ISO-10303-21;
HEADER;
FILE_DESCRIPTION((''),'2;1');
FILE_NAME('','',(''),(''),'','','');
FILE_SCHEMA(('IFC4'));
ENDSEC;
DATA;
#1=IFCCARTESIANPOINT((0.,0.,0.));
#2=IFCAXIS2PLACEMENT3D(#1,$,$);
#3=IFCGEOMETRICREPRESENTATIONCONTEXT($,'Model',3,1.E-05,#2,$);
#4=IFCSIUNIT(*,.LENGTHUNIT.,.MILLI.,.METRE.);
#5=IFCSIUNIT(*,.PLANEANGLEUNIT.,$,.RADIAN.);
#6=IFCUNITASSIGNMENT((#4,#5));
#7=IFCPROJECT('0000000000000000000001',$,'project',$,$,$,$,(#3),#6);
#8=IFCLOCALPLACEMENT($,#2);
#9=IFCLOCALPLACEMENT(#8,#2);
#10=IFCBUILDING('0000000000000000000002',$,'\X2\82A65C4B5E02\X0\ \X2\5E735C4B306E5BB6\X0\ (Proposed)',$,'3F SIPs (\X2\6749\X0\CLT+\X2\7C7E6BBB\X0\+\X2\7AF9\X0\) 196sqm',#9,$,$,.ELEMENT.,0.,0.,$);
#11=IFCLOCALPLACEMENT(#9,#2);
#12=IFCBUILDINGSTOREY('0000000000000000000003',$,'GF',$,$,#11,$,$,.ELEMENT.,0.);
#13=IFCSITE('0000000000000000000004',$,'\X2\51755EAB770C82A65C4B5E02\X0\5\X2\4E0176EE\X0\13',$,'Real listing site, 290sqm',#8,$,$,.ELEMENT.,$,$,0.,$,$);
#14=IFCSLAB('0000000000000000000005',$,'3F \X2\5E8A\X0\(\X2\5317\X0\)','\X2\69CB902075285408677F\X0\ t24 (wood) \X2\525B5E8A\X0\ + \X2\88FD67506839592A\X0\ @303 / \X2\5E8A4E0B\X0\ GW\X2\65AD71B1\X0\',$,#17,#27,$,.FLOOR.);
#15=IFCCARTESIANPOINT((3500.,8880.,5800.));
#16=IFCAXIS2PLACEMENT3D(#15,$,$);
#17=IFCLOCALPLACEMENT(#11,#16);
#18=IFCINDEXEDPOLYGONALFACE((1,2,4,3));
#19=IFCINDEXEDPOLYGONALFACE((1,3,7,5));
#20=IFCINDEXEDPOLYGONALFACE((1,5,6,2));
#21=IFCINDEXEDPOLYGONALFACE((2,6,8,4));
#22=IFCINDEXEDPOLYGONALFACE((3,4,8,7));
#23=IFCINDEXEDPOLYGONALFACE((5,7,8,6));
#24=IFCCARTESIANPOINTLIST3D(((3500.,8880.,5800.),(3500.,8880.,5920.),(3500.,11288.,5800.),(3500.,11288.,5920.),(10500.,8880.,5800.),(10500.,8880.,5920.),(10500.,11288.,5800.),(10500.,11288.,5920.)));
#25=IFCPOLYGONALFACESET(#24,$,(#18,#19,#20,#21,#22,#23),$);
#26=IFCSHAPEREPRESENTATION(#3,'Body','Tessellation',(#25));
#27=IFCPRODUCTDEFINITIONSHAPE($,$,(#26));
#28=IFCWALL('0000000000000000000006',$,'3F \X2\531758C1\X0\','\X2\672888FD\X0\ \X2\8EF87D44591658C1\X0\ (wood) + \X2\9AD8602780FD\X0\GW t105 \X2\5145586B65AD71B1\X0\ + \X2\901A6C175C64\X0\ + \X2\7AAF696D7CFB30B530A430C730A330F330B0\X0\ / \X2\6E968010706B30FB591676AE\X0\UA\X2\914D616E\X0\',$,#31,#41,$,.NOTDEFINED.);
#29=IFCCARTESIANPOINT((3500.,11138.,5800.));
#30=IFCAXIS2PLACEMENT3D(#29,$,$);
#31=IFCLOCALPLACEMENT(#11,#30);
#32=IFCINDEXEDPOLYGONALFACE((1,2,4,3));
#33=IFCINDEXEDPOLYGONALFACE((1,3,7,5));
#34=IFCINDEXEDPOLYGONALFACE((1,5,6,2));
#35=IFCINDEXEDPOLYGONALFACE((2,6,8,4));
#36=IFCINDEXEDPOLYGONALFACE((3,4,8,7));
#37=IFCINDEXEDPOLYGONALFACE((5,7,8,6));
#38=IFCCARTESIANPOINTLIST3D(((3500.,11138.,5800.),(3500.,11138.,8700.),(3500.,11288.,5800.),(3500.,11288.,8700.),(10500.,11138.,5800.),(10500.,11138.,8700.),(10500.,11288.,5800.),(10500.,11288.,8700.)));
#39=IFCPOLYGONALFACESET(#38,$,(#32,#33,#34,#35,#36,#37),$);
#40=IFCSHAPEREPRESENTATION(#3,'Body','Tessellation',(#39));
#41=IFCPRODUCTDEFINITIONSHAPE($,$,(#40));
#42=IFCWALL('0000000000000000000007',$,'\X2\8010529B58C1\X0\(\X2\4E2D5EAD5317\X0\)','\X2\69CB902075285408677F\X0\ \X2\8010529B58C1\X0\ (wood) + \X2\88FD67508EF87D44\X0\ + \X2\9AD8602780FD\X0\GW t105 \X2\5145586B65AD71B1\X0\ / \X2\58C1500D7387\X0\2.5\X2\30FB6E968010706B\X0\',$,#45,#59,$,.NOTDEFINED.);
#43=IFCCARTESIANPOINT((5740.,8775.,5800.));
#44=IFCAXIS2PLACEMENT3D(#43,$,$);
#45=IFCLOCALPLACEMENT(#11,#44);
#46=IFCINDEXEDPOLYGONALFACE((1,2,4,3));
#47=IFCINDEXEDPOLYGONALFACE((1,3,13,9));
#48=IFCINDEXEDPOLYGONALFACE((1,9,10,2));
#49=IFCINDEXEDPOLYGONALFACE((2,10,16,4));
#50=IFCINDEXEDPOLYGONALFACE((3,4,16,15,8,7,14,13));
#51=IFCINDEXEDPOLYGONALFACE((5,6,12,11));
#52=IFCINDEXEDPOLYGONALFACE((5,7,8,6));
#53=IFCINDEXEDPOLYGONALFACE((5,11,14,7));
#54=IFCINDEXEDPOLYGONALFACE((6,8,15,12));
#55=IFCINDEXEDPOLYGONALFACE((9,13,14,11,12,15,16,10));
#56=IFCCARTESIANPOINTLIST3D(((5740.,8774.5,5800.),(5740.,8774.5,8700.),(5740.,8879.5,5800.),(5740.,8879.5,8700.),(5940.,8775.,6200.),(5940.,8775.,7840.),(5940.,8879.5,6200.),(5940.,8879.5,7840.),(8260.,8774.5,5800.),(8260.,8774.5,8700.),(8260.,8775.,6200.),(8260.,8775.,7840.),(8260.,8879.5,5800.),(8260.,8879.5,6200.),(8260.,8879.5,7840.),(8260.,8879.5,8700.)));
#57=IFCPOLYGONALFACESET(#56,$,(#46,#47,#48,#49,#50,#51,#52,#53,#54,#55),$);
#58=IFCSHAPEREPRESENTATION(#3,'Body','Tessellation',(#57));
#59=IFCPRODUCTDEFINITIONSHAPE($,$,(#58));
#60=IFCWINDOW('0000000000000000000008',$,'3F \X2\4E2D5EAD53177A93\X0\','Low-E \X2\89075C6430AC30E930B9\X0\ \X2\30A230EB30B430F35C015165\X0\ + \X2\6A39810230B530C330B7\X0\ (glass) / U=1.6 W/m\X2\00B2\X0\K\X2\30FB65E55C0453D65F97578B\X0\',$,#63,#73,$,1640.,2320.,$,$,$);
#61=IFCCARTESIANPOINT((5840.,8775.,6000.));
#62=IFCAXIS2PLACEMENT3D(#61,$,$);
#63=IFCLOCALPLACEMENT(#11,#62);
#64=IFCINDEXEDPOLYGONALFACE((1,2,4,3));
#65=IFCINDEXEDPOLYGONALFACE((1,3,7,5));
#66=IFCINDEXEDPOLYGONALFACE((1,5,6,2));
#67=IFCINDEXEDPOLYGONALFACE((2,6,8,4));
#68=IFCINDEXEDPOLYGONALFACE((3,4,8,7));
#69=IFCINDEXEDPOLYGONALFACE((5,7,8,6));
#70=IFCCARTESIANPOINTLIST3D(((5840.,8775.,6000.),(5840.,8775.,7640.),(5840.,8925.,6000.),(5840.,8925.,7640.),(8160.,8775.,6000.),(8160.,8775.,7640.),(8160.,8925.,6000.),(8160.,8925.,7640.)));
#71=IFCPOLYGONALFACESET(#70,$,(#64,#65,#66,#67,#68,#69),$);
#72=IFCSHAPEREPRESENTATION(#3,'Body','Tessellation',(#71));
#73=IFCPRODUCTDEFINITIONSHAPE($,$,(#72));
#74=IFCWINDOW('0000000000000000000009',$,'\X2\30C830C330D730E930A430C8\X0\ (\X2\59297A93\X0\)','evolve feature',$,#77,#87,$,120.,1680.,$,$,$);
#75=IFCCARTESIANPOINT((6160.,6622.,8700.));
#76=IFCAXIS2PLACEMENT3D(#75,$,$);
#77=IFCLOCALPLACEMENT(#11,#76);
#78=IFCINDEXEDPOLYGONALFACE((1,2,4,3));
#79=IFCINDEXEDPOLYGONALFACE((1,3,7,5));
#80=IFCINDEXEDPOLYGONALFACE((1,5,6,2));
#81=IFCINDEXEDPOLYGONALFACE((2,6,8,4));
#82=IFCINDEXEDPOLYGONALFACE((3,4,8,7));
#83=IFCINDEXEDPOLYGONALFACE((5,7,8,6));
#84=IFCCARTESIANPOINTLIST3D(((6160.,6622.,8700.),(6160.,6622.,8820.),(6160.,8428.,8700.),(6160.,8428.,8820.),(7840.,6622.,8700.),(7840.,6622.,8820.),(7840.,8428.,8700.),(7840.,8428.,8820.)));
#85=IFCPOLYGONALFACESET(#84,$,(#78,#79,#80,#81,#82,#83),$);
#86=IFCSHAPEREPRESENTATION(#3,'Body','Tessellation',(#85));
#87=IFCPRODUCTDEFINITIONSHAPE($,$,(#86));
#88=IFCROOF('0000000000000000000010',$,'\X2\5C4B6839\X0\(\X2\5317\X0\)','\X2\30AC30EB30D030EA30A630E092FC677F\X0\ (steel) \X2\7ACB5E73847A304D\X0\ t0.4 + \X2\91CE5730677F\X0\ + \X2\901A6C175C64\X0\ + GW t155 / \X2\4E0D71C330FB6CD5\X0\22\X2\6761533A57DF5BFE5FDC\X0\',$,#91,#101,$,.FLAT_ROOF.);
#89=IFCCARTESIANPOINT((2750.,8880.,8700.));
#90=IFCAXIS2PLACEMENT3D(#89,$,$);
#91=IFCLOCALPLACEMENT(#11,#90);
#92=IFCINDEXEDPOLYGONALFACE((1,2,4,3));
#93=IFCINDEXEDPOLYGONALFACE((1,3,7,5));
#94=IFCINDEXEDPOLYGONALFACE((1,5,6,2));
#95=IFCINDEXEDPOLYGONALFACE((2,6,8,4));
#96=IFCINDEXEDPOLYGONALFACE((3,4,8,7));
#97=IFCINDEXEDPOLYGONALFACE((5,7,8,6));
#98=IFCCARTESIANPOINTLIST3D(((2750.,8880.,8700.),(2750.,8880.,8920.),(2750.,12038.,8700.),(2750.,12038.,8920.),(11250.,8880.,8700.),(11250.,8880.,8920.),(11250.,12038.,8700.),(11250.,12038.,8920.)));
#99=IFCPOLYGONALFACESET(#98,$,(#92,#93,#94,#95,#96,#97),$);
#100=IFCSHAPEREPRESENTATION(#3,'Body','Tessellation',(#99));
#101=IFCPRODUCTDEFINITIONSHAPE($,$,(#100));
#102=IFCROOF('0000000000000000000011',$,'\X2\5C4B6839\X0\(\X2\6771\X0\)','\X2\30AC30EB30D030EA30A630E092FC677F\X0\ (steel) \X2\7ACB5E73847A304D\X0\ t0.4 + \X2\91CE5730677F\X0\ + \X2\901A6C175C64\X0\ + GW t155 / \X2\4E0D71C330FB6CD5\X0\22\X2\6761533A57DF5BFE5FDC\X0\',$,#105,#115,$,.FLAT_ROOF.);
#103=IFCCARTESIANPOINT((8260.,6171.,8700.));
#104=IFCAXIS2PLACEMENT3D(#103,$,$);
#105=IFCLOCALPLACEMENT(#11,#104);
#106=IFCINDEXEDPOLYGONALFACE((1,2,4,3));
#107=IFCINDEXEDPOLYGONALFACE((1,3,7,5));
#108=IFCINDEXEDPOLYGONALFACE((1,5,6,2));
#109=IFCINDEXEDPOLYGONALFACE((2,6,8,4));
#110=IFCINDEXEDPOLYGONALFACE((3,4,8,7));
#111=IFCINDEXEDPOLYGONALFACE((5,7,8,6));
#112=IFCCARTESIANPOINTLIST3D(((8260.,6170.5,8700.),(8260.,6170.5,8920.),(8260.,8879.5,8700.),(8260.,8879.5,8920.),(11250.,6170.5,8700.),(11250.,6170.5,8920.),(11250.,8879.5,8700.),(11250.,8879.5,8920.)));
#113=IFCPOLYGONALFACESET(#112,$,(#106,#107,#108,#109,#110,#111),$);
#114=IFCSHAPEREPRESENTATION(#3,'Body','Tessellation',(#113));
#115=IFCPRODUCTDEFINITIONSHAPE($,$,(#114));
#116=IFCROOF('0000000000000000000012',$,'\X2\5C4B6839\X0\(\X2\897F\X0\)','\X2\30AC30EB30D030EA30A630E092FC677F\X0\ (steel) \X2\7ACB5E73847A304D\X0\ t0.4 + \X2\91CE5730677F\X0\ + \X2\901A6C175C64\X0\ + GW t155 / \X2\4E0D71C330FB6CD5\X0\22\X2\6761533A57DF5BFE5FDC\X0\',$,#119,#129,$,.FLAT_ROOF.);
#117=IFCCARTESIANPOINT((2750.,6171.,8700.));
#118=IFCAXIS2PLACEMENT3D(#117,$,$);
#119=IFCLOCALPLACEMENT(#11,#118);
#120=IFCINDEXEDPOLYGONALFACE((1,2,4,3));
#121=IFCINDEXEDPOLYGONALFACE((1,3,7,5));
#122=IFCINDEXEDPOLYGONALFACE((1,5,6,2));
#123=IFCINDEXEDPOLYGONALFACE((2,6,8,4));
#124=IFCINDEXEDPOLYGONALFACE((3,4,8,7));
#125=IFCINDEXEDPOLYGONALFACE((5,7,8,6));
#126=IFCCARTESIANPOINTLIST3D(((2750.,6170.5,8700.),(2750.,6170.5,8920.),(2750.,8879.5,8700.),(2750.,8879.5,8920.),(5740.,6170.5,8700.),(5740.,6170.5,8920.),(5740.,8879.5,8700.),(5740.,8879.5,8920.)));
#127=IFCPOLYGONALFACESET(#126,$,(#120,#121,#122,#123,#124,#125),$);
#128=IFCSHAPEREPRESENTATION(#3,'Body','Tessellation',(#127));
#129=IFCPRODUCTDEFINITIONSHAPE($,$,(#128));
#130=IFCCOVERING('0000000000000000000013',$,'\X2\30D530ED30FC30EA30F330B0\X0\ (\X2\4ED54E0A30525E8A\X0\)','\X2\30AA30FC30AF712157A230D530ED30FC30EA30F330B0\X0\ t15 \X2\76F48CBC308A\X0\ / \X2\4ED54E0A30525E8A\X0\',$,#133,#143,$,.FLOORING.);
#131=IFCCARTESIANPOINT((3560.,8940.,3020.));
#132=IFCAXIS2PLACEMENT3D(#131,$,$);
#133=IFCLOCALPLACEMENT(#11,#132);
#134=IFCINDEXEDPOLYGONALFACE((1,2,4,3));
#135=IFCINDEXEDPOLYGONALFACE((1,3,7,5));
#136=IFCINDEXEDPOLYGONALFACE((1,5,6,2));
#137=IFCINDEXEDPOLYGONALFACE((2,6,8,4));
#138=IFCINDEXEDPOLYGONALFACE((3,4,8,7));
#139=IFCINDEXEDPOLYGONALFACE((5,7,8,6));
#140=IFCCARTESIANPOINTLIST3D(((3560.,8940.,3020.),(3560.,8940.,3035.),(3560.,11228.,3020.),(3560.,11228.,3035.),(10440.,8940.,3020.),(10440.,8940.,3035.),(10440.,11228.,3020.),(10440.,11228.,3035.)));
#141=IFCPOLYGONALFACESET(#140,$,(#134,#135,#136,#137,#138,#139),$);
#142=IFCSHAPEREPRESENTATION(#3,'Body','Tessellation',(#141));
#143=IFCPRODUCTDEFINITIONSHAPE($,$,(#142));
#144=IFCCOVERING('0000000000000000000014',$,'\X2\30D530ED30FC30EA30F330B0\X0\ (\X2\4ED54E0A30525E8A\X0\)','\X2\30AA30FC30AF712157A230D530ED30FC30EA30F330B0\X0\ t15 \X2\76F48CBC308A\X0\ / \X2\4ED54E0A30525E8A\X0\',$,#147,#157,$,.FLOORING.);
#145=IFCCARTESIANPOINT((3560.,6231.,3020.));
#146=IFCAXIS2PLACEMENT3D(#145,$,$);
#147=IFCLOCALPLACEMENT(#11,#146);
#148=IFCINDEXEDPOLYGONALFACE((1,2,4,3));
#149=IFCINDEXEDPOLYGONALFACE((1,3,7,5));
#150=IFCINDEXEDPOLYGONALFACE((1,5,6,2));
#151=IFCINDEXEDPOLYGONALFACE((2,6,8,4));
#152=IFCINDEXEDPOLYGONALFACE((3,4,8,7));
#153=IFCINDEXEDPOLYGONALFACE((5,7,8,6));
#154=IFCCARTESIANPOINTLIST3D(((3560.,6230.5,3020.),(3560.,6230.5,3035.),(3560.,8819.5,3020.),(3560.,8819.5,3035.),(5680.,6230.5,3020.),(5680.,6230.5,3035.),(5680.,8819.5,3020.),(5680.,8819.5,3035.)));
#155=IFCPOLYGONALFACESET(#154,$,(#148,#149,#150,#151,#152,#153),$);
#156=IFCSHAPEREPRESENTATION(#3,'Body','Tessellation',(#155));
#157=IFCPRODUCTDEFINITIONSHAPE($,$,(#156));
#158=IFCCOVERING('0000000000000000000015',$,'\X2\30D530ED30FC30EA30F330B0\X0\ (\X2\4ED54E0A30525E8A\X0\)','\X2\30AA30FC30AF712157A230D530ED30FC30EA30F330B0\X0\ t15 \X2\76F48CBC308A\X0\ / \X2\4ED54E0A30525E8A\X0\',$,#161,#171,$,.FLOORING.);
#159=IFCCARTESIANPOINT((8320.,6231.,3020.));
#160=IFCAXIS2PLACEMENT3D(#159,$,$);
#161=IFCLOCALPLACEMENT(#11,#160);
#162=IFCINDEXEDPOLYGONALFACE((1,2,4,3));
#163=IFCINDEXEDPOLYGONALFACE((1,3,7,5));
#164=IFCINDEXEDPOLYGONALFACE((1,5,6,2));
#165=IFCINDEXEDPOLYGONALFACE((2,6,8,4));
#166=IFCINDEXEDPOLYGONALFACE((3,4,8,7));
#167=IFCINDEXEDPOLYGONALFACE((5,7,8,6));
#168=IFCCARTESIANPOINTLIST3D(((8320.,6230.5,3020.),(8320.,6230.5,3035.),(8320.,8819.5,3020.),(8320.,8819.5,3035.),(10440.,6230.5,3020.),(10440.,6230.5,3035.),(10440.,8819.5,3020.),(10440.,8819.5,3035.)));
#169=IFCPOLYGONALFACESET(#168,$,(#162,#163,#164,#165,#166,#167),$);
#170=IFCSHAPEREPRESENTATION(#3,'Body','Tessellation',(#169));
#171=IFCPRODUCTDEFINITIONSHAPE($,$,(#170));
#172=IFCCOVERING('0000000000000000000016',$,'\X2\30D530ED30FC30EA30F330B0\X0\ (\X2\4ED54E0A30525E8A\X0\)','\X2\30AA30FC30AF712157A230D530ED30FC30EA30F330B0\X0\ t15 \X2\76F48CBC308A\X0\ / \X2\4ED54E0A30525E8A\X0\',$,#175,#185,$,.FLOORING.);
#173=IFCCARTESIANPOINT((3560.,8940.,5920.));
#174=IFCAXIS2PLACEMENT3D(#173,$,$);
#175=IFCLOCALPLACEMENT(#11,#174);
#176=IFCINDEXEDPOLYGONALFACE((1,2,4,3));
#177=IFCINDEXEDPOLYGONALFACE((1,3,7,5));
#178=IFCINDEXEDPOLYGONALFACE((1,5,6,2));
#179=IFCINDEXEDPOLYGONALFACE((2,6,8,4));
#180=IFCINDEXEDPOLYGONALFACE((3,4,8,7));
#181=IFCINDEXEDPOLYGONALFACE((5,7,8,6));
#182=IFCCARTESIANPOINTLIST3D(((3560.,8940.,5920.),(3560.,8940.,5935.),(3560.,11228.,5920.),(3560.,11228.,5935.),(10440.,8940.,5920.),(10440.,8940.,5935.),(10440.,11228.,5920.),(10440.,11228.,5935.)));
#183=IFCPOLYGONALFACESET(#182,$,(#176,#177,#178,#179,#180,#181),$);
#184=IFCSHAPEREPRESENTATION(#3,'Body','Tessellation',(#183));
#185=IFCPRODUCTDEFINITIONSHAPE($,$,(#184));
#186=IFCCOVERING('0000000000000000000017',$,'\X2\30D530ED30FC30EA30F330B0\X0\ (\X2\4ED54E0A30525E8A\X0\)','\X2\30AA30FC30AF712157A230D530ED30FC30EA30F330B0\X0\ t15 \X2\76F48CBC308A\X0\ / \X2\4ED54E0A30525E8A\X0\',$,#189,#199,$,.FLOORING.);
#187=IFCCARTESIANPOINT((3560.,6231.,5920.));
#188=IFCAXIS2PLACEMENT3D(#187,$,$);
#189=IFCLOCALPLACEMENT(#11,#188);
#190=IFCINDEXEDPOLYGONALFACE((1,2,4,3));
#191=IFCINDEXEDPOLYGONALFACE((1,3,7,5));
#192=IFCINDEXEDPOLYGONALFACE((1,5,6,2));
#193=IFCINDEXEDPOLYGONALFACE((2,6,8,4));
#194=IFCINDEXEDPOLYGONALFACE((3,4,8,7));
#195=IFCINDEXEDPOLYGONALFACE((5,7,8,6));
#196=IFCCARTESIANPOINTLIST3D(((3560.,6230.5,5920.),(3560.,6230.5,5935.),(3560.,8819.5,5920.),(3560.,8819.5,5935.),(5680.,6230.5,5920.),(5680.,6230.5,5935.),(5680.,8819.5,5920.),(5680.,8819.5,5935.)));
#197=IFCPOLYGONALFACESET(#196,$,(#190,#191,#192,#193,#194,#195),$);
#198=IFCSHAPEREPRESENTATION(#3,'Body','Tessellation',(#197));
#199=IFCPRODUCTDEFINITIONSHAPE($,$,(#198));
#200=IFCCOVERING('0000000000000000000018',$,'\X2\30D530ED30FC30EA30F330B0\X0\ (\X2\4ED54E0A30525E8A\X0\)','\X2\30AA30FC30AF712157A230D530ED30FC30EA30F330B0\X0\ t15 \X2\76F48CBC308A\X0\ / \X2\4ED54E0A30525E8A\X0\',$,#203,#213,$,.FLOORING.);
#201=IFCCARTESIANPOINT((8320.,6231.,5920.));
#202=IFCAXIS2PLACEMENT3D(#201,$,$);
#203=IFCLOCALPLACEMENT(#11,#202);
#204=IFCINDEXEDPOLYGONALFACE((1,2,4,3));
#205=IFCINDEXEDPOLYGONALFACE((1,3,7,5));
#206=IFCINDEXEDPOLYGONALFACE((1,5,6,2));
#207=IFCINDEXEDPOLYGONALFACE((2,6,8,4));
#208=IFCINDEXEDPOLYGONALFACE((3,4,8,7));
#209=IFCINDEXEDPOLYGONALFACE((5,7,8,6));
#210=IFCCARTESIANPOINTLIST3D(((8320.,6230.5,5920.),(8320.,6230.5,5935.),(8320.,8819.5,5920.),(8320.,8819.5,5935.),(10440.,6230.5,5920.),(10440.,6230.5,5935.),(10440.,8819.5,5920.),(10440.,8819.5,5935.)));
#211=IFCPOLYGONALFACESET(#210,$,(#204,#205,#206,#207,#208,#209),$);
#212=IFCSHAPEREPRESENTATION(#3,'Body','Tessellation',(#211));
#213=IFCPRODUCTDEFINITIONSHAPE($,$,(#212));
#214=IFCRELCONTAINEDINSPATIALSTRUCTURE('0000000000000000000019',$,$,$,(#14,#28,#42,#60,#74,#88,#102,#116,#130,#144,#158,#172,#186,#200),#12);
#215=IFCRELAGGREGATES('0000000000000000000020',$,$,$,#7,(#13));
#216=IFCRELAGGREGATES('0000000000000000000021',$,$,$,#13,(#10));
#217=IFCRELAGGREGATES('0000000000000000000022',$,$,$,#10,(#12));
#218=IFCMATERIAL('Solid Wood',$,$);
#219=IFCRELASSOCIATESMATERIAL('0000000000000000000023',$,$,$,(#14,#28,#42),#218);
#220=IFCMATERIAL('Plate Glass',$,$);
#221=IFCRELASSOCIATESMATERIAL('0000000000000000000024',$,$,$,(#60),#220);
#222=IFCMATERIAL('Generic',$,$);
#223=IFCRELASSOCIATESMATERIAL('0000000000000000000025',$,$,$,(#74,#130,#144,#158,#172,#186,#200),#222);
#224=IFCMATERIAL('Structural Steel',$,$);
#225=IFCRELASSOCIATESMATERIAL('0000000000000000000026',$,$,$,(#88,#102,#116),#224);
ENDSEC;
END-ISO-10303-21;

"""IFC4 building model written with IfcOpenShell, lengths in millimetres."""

from ifc_helpers import new_model, si_unit, frame, frame_2d, origin, place, context, project, spatial, rectangle, extrude, material, element, fill, save


model = new_model("IFC4")

# Units and contexts
model_context = context("Model", 3, precision=1e-05, world=origin())
ifc_project = project(units=[si_unit("LENGTHUNIT", "METRE", prefix="MILLI"), si_unit("PLANEANGLEUNIT", "RADIAN")], contexts=[model_context])

# Site, building, storey
site_placement = place(None, origin())
site = spatial("IfcSite", under=ifc_project, at=site_placement, Name="兵庫県芦屋市5丁目13", ObjectType="Real listing site, 290sqm", CompositionType="ELEMENT", RefElevation=0.0)
building_placement = place(site_placement, origin())
building = spatial("IfcBuilding", under=site, at=building_placement, Name="芦屋市 平屋の家 (Proposed)", ObjectType="3F SIPs (杉CLT+籾殻+竹) 196sqm", CompositionType="ELEMENT", ElevationOfRefHeight=0.0, ElevationOfTerrain=0.0)
storey_placement = place(building_placement, origin())
storey = spatial("IfcBuildingStorey", under=building, at=storey_placement, Name="GF", CompositionType="ELEMENT", Elevation=0.0)

# Slab
ifc_material_1 = material(Name="Solid Wood")
slab_placement = place(storey_placement, frame((3500.0, 8880.0, 5800.0)))
element("IfcSlab", 1, at=slab_placement, inside=storey, material=ifc_material_1, Name="3F 床(北)", Description="構造用合板 t24 (wood) 剛床 + 製材根太 @303 / 床下 GW断熱", PredefinedType="FLOOR", context=model_context, shape_type="SweptSolid", body=[
    extrude(rectangle(XDim=7000.0, YDim=2408.0, at=frame_2d((3500.0, 1204.0))), frame((3500.0, 8880.0, 5800.0)), (0.0, 0.0, 1.0), 120.0),
])

# Wall
wall_1_placement = place(storey_placement, frame((3500.0, 11138.0, 5800.0)))
element("IfcWall", 2, at=wall_1_placement, inside=storey, material=ifc_material_1, Name="3F 北壁", Description="木製 軸組外壁 (wood) + 高性能GW t105 充填断熱 + 通気層 + 窯業系サイディング / 準耐火・外皮UA配慮", PredefinedType="NOTDEFINED", context=model_context, shape_type="SweptSolid", body=[
    extrude(rectangle(XDim=7000.0, YDim=150.0, at=frame_2d((3500.0, 75.0))), frame((3500.0, 11138.0, 5800.0)), (0.0, 0.0, 1.0), 2900.0),
])

# Wall, opening, window
wall_2_placement = place(storey_placement, frame((5740.0, 8775.0, 5800.0)))
wall_2 = element("IfcWall", 3, at=wall_2_placement, inside=storey, material=ifc_material_1, Name="耐力壁(中庭北)", Description="構造用合板 耐力壁 (wood) + 製材軸組 + 高性能GW t105 充填断熱 / 壁倍率2.5・準耐火", PredefinedType="NOTDEFINED", context=model_context, shape_type="SweptSolid", body=[
    extrude(rectangle(XDim=2520.0, YDim=105.0, at=frame_2d((1260.0, 52.0))), frame((5740.0, 8775.0, 5800.0)), (0.0, 0.0, 1.0), 2900.0),
])
opening_placement = place(storey_placement, frame((5840.0, 8775.0, 6000.0)))
opening = element("IfcOpeningElement", 4, at=opening_placement, cuts=wall_2, PredefinedType="NOTDEFINED", context=model_context, shape_type="SweptSolid", body=[
    extrude(rectangle(XDim=2320.0, YDim=150.0, at=frame_2d((1160.0, 75.0))), frame((5840.0, 8775.0, 6000.0)), (0.0, 0.0, 1.0), 1640.0),
])
ifc_material_2 = material(Name="Plate Glass")
window_1_placement = place(storey_placement, frame((5840.0, 8775.0, 6000.0)))
window_1 = element("IfcWindow", 5, at=window_1_placement, inside=storey, material=ifc_material_2, Name="3F 中庭北窓", Description="Low-E 複層ガラス アルゴン封入 + 樹脂サッシ (glass) / U=1.6 W/m²K・日射取得型", OverallHeight=1640.0, OverallWidth=2320.0, context=model_context, shape_type="SweptSolid", body=[
    extrude(rectangle(XDim=2320.0, YDim=150.0, at=frame_2d((1160.0, 75.0))), frame((5840.0, 8775.0, 6000.0)), (0.0, 0.0, 1.0), 1640.0),
])
fill(opening, window_1)

# Window
ifc_material_3 = material(Name="Generic")
window_2_placement = place(storey_placement, frame((6160.0, 6622.0, 8700.0)))
element("IfcWindow", 6, at=window_2_placement, inside=storey, material=ifc_material_3, Name="トップライト (天窓)", Description="evolve feature", OverallHeight=120.0, OverallWidth=1680.0, context=model_context, shape_type="SweptSolid", body=[
    extrude(rectangle(XDim=1680.0, YDim=1806.0, at=frame_2d((840.0, 903.0))), frame((6160.0, 6622.0, 8700.0)), (0.0, 0.0, 1.0), 120.0),
])

# Roofs
ifc_material_4 = material(Name="Structural Steel")
roof_1_placement = place(storey_placement, frame((2750.0, 8880.0, 8700.0)))
element("IfcRoof", 7, at=roof_1_placement, inside=storey, material=ifc_material_4, Name="屋根(北)", Description="ガルバリウム鋼板 (steel) 立平葺き t0.4 + 野地板 + 通気層 + GW t155 / 不燃・法22条区域対応", PredefinedType="FLAT_ROOF", context=model_context, shape_type="SweptSolid", body=[
    extrude(rectangle(XDim=8500.0, YDim=3158.0, at=frame_2d((4250.0, 1579.0))), frame((2750.0, 8880.0, 8700.0)), (0.0, 0.0, 1.0), 220.0),
])
roof_2_placement = place(storey_placement, frame((8260.0, 6171.0, 8700.0)))
element("IfcRoof", 8, at=roof_2_placement, inside=storey, material=ifc_material_4, Name="屋根(東)", Description="ガルバリウム鋼板 (steel) 立平葺き t0.4 + 野地板 + 通気層 + GW t155 / 不燃・法22条区域対応", PredefinedType="FLAT_ROOF", context=model_context, shape_type="SweptSolid", body=[
    extrude(rectangle(XDim=2990.0, YDim=2709.0, at=frame_2d((1495.0, 1354.0))), frame((8260.0, 6171.0, 8700.0)), (0.0, 0.0, 1.0), 220.0),
])
roof_3_placement = place(storey_placement, frame((2750.0, 6171.0, 8700.0)))
element("IfcRoof", 9, at=roof_3_placement, inside=storey, material=ifc_material_4, Name="屋根(西)", Description="ガルバリウム鋼板 (steel) 立平葺き t0.4 + 野地板 + 通気層 + GW t155 / 不燃・法22条区域対応", PredefinedType="FLAT_ROOF", context=model_context, shape_type="SweptSolid", body=[
    extrude(rectangle(XDim=2990.0, YDim=2709.0, at=frame_2d((1495.0, 1354.0))), frame((2750.0, 6171.0, 8700.0)), (0.0, 0.0, 1.0), 220.0),
])

# Coverings
covering_1_placement = place(storey_placement, frame((3560.0, 8940.0, 3020.0)))
element("IfcCovering", 10, at=covering_1_placement, inside=storey, material=ifc_material_3, Name="フローリング (仕上げ床)", Description="オーク無垢フローリング t15 直貼り / 仕上げ床", PredefinedType="FLOORING", context=model_context, shape_type="SweptSolid", body=[
    extrude(rectangle(XDim=6880.0, YDim=2288.0, at=frame_2d((3440.0, 1144.0))), frame((3560.0, 8940.0, 3020.0)), (0.0, 0.0, 1.0), 15.0),
])
covering_2_placement = place(storey_placement, frame((3560.0, 6231.0, 3020.0)))
element("IfcCovering", 11, at=covering_2_placement, inside=storey, material=ifc_material_3, Name="フローリング (仕上げ床)", Description="オーク無垢フローリング t15 直貼り / 仕上げ床", PredefinedType="FLOORING", context=model_context, shape_type="SweptSolid", body=[
    extrude(rectangle(XDim=2120.0, YDim=2589.0, at=frame_2d((1060.0, 1294.0))), frame((3560.0, 6231.0, 3020.0)), (0.0, 0.0, 1.0), 15.0),
])
covering_3_placement = place(storey_placement, frame((8320.0, 6231.0, 3020.0)))
element("IfcCovering", 12, at=covering_3_placement, inside=storey, material=ifc_material_3, Name="フローリング (仕上げ床)", Description="オーク無垢フローリング t15 直貼り / 仕上げ床", PredefinedType="FLOORING", context=model_context, shape_type="SweptSolid", body=[
    extrude(rectangle(XDim=2120.0, YDim=2589.0, at=frame_2d((1060.0, 1294.0))), frame((8320.0, 6231.0, 3020.0)), (0.0, 0.0, 1.0), 15.0),
])
covering_4_placement = place(storey_placement, frame((3560.0, 8940.0, 5920.0)))
element("IfcCovering", 13, at=covering_4_placement, inside=storey, material=ifc_material_3, Name="フローリング (仕上げ床)", Description="オーク無垢フローリング t15 直貼り / 仕上げ床", PredefinedType="FLOORING", context=model_context, shape_type="SweptSolid", body=[
    extrude(rectangle(XDim=6880.0, YDim=2288.0, at=frame_2d((3440.0, 1144.0))), frame((3560.0, 8940.0, 5920.0)), (0.0, 0.0, 1.0), 15.0),
])
covering_5_placement = place(storey_placement, frame((3560.0, 6231.0, 5920.0)))
element("IfcCovering", 14, at=covering_5_placement, inside=storey, material=ifc_material_3, Name="フローリング (仕上げ床)", Description="オーク無垢フローリング t15 直貼り / 仕上げ床", PredefinedType="FLOORING", context=model_context, shape_type="SweptSolid", body=[
    extrude(rectangle(XDim=2120.0, YDim=2589.0, at=frame_2d((1060.0, 1294.0))), frame((3560.0, 6231.0, 5920.0)), (0.0, 0.0, 1.0), 15.0),
])
covering_6_placement = place(storey_placement, frame((8320.0, 6231.0, 5920.0)))
element("IfcCovering", 15, at=covering_6_placement, inside=storey, material=ifc_material_3, Name="フローリング (仕上げ床)", Description="オーク無垢フローリング t15 直貼り / 仕上げ床", PredefinedType="FLOORING", context=model_context, shape_type="SweptSolid", body=[
    extrude(rectangle(XDim=2120.0, YDim=2589.0, at=frame_2d((1060.0, 1294.0))), frame((8320.0, 6231.0, 5920.0)), (0.0, 0.0, 1.0), 15.0),
])

save(model, "model.ifc")
